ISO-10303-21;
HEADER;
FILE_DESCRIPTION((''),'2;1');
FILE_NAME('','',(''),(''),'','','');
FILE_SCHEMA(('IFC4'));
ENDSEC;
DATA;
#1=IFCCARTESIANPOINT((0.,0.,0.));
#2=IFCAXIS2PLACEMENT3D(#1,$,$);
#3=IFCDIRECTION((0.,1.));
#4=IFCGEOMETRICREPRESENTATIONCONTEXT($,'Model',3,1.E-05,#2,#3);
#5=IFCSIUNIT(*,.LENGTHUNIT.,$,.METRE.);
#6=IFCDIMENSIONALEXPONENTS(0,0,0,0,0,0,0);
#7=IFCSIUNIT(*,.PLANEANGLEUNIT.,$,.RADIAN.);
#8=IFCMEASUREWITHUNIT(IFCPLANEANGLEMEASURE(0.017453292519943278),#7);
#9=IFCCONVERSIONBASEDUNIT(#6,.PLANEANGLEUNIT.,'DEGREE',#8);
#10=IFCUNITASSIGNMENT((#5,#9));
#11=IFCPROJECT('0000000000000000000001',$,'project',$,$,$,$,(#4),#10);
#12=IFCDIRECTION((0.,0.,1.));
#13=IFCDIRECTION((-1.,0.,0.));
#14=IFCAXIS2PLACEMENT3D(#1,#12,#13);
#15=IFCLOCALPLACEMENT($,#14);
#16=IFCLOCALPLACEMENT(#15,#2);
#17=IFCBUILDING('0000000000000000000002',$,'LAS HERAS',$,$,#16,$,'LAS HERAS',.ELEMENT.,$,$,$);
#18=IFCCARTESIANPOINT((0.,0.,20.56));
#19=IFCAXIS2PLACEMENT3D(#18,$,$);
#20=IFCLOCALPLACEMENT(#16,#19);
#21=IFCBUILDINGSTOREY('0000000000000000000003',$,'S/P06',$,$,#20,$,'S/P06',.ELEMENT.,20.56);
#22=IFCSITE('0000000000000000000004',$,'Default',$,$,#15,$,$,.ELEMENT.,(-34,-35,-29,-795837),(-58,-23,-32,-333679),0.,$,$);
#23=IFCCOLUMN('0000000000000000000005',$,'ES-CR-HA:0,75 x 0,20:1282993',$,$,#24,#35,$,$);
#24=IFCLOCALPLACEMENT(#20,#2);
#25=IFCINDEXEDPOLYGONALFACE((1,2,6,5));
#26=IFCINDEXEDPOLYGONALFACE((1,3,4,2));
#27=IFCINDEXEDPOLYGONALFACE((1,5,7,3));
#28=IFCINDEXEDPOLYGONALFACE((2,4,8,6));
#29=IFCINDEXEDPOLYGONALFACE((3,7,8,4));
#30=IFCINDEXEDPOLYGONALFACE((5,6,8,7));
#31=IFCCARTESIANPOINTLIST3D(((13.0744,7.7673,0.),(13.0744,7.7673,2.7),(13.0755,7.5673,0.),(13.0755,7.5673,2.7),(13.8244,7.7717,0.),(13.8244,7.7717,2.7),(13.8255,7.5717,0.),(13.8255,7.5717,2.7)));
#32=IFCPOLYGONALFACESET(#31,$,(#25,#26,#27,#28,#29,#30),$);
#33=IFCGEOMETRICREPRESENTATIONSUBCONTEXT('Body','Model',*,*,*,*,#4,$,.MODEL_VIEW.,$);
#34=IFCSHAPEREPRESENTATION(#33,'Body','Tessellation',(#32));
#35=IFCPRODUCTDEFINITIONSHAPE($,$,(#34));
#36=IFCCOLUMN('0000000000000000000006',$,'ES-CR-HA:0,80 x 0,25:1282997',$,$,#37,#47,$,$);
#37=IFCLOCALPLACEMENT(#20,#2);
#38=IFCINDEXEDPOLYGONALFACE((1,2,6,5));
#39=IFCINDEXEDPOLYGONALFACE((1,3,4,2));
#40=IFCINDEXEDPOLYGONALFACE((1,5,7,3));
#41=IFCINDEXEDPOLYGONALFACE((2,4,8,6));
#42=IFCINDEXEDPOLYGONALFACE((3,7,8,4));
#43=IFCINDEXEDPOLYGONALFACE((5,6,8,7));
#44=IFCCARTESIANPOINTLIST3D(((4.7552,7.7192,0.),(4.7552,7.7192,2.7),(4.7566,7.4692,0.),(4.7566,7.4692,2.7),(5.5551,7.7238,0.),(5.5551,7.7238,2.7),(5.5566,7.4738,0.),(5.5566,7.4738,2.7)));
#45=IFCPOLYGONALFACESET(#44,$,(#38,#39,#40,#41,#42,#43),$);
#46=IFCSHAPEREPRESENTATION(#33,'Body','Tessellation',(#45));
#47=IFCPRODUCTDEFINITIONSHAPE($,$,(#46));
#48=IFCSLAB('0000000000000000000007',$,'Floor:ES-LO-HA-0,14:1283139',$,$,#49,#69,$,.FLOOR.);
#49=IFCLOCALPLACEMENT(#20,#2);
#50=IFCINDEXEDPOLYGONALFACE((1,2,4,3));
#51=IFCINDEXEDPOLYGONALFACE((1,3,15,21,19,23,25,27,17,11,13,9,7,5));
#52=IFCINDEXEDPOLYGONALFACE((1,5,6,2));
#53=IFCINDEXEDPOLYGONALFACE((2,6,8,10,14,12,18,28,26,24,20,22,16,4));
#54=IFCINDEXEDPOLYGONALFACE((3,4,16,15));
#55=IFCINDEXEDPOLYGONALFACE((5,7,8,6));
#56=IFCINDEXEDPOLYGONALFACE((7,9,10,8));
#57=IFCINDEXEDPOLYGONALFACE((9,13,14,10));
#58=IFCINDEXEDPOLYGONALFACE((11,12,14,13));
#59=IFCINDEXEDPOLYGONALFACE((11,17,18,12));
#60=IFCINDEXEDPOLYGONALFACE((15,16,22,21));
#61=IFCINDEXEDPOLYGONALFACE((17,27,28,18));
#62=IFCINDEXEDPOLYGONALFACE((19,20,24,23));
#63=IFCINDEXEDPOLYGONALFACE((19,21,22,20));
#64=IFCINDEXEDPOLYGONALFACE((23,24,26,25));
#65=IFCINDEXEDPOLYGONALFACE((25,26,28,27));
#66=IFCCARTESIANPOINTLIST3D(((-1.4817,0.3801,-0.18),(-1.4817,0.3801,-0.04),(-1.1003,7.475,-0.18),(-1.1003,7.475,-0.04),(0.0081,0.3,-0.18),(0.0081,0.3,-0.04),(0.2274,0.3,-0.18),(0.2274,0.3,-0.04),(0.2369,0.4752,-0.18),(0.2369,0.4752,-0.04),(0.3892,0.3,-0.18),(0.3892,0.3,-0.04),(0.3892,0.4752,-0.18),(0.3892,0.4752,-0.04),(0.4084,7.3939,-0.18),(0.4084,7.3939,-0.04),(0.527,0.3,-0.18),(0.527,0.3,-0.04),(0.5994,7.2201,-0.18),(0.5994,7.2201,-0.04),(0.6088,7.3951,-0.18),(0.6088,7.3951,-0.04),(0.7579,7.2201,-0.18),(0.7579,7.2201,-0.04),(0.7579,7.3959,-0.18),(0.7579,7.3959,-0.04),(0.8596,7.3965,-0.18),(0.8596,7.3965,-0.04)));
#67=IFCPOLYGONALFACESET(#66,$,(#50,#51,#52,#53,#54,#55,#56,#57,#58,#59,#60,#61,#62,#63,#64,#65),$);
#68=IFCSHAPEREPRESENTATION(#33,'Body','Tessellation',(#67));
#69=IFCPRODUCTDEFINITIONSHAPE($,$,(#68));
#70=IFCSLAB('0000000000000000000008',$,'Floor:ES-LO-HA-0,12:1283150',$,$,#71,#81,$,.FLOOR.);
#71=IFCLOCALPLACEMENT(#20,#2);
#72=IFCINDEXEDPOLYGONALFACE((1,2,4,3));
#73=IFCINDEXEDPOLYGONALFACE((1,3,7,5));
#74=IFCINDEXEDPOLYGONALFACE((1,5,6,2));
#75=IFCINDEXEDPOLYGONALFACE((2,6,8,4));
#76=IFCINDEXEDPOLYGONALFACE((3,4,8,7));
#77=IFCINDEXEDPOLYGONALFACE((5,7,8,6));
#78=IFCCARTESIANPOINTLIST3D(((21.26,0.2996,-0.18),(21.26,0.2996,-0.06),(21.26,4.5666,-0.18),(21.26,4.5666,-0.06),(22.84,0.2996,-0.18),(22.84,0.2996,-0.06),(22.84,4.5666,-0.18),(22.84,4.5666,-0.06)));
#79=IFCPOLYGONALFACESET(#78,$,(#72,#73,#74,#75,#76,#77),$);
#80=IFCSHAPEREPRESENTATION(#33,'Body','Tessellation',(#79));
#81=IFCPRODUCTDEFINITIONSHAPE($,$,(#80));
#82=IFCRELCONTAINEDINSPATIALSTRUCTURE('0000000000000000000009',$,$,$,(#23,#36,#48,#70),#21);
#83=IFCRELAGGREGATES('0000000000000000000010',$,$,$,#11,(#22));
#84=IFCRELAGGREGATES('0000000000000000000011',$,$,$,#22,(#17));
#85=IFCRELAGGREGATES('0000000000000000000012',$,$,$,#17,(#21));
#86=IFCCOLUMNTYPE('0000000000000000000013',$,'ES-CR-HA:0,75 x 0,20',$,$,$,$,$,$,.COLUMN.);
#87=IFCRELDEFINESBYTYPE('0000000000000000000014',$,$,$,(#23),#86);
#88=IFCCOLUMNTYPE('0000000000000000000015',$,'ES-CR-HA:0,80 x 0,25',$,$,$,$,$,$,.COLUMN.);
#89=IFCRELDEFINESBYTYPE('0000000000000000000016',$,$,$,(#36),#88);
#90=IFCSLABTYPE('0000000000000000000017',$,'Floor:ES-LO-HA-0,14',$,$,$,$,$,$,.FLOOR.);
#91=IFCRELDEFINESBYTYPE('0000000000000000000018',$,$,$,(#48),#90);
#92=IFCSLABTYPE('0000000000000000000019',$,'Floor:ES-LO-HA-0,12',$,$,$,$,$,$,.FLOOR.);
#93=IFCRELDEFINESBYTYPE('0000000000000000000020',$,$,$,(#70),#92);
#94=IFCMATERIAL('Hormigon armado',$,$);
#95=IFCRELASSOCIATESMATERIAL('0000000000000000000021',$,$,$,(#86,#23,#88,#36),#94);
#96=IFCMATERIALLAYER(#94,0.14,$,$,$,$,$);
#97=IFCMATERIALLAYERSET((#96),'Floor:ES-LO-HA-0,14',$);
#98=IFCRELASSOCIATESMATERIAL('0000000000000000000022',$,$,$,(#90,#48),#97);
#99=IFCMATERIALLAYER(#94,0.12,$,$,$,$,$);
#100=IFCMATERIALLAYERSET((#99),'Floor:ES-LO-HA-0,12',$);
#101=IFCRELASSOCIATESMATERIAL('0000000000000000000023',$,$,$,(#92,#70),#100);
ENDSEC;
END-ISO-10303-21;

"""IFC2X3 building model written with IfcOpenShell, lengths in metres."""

from ifc_helpers import new_model, entity, si_unit, converted_unit, direction, frame, frame_2d, origin, place, context, subcontext, project, spatial, polyline, rectangle, outline, extrude, source, transform, mapped, material, layer, layer_set, layer_usage, type_object, type_shapes, element, save


model = new_model("IFC2X3")

# Units and contexts
model_context = context("Model", 3, precision=1e-05, world=origin(), true_north=direction((0.0, 1.0)))
body_context = subcontext(model_context, "Body", "Model", "MODEL_VIEW")
ifc_project = project(units=[si_unit("LENGTHUNIT", "METRE"), converted_unit("PLANEANGLEUNIT", "DEGREE", entity("IfcPlaneAngleMeasure", 0.017453292519943278), si_unit("PLANEANGLEUNIT", "RADIAN"), dimensions=[0, 0, 0, 0, 0, 0, 0])], contexts=[model_context])

# Site, building, storey
site_placement = place(None, frame((0.0, 0.0, 0.0), z_axis=(0.0, 0.0, 1.0), x_axis=(-1.0, 0.0, 0.0)))
site = spatial("IfcSite", under=ifc_project, at=site_placement, Name="Default", CompositionType="ELEMENT", RefLatitude=(-34, -35, -29, -795837), RefLongitude=(-58, -23, -32, -333679), RefElevation=0.0)
building_placement = place(site_placement, origin())
building = spatial("IfcBuilding", under=site, at=building_placement, Name="LAS HERAS", LongName="LAS HERAS", CompositionType="ELEMENT")
storey_placement = place(building_placement, frame((0.0, 0.0, 20.56)))
storey = spatial("IfcBuildingStorey", under=building, at=storey_placement, Name="S/P06", LongName="S/P06", CompositionType="ELEMENT", Elevation=20.56)

# Columns
ifc_material = material(Name="Hormigon armado")
column_type_1 = type_object("IfcColumnType", Name="ES-CR-HA:0,75 x 0,20", PredefinedType="COLUMN", material=ifc_material)
shared_shape_1 = source(origin(), body_context, "Body", "SweptSolid", [
    extrude(rectangle(XDim=0.75, YDim=0.2, at=frame_2d((0.0, 0.0), x_axis=(1.0, 0.0))), frame((13.4499, 7.6695, 20.56), z_axis=(0.0, 0.0, 1.0), x_axis=(-0.999983, -0.005788, 0.0)), (0.0, 0.0, 1.0), 2.7),
])
type_shapes(column_type_1, [shared_shape_1])
column_1_placement = place(storey_placement, frame((0.0, 0.0, -20.56)))
element("IfcColumn", 1, at=column_1_placement, inside=storey, type_object=column_type_1, material=ifc_material, Name="ES-CR-HA:0,75 x 0,20:1282993", context=body_context, shape_type="MappedRepresentation", body=[
    mapped(shared_shape_1, transform((0.0, 0.0, 0.0), scale=1.0)),
])
column_type_2 = type_object("IfcColumnType", Name="ES-CR-HA:0,80 x 0,25", PredefinedType="COLUMN", material=ifc_material)
shared_shape_2 = source(origin(), body_context, "Body", "SweptSolid", [
    extrude(rectangle(XDim=0.8, YDim=0.25, at=frame_2d((0.0, 0.0), x_axis=(1.0, 0.0))), frame((5.1559, 7.5965, 20.56), z_axis=(0.0, 0.0, 1.0), x_axis=(-0.999983, -0.005788, 0.0)), (0.0, 0.0, 1.0), 2.7),
])
type_shapes(column_type_2, [shared_shape_2])
column_2_placement = place(storey_placement, frame((0.0, 0.0, -20.56)))
element("IfcColumn", 2, at=column_2_placement, inside=storey, type_object=column_type_2, material=ifc_material, Name="ES-CR-HA:0,80 x 0,25:1282997", context=body_context, shape_type="MappedRepresentation", body=[
    mapped(shared_shape_2, transform((0.0, 0.0, 0.0), scale=1.0)),
])

# Slab, openings
ifc_layer_1 = layer(ifc_material, 0.14)
ifc_layer_set_1 = layer_set([ifc_layer_1], Name="Floor:ES-LO-HA-0,14")
ifc_layer_usage_1 = layer_usage(ifc_layer_set_1, "AXIS3", "POSITIVE", 0.0)
slab_type_1 = type_object("IfcSlabType", Name="Floor:ES-LO-HA-0,14", PredefinedType="FLOOR", material=ifc_layer_set_1)
slab_1_placement = place(storey_placement, origin())
slab_1 = element("IfcSlab", 3, at=slab_1_placement, inside=storey, type_object=slab_type_1, material=ifc_layer_usage_1, Name="Floor:ES-LO-HA-0,14:1283139", PredefinedType="FLOOR", context=body_context, shape_type="SweptSolid", body=[
    extrude(outline(polyline([(-0.2993, -3.5591), (-0.1615, -3.5591), (-0.1615, -3.3839), (-0.0091, -3.3839), (0.0003, -3.5591), (0.2196, -3.5591), (1.7094, -3.479), (1.328, 3.6159), (-0.1807, 3.5348), (-0.3811, 3.536), (-0.3717, 3.3611), (-0.5302, 3.3611), (-0.5302, 3.5368), (-0.6319, 3.5374), (-0.2993, -3.5591)])), frame((0.2277, 3.8591, -0.04), z_axis=(0.0, 0.0, -1.0), x_axis=(-1.0, 0.0, 0.0)), (0.0, 0.0, 1.0), 0.14),
])
opening_1_placement = place(slab_1_placement, origin())
element("IfcOpeningElement", 4, at=opening_1_placement, cuts=slab_1, ObjectType="Opening", context=body_context, shape_type="SweptSolid", body=[
    extrude(outline(polyline([(0.2369, 0.4752), (0.2274, 0.3), (0.3892, 0.3), (0.3892, 0.4752), (0.2369, 0.4752)])), frame((0.0, 0.0, -0.04)), (0.0, 0.0, -1.0), 0.14),
])
opening_2_placement = place(slab_1_placement, origin())
element("IfcOpeningElement", 5, at=opening_2_placement, cuts=slab_1, ObjectType="Opening", context=body_context, shape_type="SweptSolid", body=[
    extrude(outline(polyline([(0.7579, 7.2201), (0.7579, 7.3959), (0.6088, 7.3951), (0.5994, 7.2201), (0.7579, 7.2201)])), frame((0.0, 0.0, -0.04)), (0.0, 0.0, -1.0), 0.14),
])

# Slab
ifc_layer_2 = layer(ifc_material, 0.12)
ifc_layer_set_2 = layer_set([ifc_layer_2], Name="Floor:ES-LO-HA-0,12")
ifc_layer_usage_2 = layer_usage(ifc_layer_set_2, "AXIS3", "POSITIVE", 0.0)
slab_type_2 = type_object("IfcSlabType", Name="Floor:ES-LO-HA-0,12", PredefinedType="FLOOR", material=ifc_layer_set_2)
slab_2_placement = place(storey_placement, origin())
element("IfcSlab", 6, at=slab_2_placement, inside=storey, type_object=slab_type_2, material=ifc_layer_usage_2, Name="Floor:ES-LO-HA-0,12:1283150", PredefinedType="FLOOR", context=body_context, shape_type="SweptSolid", body=[
    extrude(rectangle(XDim=4.2671, YDim=1.58, at=frame_2d((0.0, 0.0), x_axis=(1.0, 0.0))), frame((22.05, 2.4331, -0.06), z_axis=(0.0, 0.0, -1.0), x_axis=(0.0, 1.0, 0.0)), (0.0, 0.0, 1.0), 0.12),
])

save(model, "model.ifc")
